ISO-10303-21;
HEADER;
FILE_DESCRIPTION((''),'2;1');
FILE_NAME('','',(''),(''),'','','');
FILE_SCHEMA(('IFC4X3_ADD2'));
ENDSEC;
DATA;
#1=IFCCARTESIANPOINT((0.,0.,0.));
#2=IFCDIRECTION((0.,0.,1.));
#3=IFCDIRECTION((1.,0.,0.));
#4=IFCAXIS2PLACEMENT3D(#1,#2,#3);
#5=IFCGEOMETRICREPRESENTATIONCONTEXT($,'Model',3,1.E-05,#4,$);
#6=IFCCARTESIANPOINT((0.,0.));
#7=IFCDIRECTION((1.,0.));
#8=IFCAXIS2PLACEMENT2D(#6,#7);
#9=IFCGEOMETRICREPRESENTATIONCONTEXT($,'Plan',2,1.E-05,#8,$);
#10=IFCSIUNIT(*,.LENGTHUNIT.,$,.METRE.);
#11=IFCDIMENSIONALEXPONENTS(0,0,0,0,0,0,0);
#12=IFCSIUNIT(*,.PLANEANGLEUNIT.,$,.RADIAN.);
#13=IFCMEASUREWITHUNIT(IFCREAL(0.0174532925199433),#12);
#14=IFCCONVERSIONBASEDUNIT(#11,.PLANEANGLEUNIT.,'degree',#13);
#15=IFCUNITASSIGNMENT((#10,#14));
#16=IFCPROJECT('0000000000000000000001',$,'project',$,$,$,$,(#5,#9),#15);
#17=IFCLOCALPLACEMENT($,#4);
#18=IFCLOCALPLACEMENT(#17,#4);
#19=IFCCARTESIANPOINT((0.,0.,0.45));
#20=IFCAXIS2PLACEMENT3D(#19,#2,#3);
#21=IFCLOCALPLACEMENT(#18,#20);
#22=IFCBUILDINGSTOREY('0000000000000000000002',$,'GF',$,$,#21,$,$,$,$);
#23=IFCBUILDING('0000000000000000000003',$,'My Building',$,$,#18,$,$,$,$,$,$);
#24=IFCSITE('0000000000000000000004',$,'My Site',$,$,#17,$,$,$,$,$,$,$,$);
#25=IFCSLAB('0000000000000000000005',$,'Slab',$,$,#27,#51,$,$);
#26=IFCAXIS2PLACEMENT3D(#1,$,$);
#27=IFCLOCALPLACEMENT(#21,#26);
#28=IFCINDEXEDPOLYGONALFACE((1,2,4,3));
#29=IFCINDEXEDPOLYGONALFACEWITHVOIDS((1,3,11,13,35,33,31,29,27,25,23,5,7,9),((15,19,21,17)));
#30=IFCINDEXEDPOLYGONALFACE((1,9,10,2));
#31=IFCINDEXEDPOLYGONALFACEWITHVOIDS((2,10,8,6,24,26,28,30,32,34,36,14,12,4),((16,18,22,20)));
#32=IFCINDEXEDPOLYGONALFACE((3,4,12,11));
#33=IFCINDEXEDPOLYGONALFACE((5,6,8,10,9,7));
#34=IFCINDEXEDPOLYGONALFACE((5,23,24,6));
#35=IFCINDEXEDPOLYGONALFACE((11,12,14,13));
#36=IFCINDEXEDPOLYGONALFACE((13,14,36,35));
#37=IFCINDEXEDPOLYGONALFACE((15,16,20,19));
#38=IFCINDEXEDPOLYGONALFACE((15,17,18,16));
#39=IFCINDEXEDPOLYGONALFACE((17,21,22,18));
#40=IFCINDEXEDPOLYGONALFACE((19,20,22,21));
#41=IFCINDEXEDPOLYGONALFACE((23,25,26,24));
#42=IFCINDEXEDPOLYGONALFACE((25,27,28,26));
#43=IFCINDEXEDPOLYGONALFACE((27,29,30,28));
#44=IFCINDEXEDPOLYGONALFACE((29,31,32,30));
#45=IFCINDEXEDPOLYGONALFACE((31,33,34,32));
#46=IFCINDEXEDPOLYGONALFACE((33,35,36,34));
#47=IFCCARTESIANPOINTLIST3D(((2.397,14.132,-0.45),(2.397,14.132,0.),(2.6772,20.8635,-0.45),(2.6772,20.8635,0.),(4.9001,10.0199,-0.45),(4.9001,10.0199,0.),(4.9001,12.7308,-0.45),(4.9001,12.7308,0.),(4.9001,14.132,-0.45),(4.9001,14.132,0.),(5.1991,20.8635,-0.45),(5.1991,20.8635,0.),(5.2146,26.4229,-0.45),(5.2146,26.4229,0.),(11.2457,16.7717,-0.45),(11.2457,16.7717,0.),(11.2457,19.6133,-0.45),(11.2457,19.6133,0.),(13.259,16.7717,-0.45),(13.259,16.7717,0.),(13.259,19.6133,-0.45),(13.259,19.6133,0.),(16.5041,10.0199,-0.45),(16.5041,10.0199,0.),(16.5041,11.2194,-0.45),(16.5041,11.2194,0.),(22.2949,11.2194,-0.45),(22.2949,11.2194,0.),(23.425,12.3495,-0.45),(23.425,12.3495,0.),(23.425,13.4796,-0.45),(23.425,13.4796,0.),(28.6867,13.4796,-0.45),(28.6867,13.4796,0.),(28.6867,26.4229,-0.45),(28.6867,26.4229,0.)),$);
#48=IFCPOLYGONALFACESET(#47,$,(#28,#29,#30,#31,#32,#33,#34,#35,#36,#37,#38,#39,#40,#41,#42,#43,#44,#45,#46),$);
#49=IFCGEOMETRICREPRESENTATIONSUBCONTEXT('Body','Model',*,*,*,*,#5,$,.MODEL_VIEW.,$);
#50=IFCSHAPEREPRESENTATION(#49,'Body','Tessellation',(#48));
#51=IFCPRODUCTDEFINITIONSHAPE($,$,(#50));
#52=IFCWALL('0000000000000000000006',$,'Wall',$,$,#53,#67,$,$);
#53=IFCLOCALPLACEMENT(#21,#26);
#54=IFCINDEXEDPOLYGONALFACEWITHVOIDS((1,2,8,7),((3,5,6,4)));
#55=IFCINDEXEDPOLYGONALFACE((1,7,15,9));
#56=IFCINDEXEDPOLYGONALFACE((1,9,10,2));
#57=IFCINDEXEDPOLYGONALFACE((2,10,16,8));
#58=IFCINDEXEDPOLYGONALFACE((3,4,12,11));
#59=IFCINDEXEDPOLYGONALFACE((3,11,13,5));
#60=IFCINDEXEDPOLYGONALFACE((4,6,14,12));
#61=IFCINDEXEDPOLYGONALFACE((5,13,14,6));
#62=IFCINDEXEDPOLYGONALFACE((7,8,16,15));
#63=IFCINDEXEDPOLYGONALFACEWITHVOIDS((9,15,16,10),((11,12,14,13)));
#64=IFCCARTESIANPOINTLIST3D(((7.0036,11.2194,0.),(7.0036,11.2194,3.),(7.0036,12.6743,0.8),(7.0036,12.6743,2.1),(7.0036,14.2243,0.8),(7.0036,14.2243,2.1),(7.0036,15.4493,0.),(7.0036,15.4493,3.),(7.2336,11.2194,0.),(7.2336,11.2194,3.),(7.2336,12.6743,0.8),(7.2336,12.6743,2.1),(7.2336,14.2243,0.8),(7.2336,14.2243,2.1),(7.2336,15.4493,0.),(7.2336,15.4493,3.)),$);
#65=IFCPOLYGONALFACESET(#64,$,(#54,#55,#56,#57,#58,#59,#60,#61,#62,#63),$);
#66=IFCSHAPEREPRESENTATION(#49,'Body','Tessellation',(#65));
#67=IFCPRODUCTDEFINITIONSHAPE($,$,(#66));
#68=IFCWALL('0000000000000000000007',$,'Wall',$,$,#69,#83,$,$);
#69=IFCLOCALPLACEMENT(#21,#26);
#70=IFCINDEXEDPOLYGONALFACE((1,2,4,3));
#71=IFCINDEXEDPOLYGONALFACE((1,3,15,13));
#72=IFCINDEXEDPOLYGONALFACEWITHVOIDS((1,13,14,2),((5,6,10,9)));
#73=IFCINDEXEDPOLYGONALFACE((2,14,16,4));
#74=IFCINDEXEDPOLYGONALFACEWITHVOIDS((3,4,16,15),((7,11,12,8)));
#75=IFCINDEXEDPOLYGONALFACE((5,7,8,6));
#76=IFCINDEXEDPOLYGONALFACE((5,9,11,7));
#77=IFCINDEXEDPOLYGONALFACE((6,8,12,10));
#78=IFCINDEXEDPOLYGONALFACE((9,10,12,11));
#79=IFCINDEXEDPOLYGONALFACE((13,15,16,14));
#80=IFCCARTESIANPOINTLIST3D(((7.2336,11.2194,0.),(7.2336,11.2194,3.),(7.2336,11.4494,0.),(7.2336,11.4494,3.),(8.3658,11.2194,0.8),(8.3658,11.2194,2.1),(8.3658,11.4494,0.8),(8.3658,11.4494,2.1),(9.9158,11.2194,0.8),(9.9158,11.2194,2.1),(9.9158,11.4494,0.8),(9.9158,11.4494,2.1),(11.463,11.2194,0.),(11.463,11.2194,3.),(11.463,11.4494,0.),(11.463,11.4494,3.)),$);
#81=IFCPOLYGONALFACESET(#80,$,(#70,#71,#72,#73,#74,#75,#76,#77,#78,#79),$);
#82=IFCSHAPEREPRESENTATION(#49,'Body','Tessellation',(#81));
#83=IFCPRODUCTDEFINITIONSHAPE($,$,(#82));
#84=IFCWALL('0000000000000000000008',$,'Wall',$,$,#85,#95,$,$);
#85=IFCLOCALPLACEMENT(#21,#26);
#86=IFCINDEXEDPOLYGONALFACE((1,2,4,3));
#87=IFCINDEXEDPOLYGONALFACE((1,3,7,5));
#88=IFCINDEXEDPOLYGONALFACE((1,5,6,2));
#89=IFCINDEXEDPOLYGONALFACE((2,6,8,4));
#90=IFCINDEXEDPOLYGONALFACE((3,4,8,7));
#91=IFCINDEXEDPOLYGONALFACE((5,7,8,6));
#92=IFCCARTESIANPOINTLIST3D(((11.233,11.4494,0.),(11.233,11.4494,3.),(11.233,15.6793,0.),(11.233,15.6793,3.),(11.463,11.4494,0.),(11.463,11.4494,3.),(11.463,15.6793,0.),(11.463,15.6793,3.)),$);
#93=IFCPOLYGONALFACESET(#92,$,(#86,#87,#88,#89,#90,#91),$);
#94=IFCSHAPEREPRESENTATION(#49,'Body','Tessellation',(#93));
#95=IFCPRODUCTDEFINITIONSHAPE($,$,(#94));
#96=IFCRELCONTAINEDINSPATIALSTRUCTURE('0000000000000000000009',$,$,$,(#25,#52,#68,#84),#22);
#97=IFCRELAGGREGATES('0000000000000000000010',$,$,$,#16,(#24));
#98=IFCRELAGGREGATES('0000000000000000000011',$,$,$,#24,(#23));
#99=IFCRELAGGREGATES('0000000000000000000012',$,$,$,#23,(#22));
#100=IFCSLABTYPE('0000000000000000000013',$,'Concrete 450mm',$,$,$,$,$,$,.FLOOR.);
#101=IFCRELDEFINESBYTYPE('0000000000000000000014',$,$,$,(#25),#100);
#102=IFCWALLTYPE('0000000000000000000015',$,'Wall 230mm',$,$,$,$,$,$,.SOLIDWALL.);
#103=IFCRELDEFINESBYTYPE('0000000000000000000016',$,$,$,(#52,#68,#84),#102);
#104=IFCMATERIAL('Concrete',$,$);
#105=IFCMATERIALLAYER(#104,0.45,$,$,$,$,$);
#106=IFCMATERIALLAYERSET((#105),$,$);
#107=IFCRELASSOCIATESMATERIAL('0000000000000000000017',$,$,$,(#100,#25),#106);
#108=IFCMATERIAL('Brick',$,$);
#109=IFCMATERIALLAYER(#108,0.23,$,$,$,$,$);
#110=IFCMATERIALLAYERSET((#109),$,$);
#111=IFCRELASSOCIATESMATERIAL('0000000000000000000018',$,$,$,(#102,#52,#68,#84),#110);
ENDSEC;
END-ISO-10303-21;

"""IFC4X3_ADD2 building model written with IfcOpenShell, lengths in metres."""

from ifc_helpers import new_model, entity, si_unit, converted_unit, frame, origin_with_axes, origin_2d_with_axis, place, context, subcontext, project, spatial, line, indexed_curve, outline, extrude, source, transform, mapped, material, layer, layer_set, layer_usage, type_object, element, save


model = new_model("IFC4X3_ADD2")

# Units and contexts
model_context = context("Model", 3, precision=1e-05, world=origin_with_axes())
plan_context = context("Plan", 2, precision=1e-05, world=origin_2d_with_axis())
body_context_1 = subcontext(model_context, "Body", "Model", "MODEL_VIEW")
ifc_project = project(units=[si_unit("LENGTHUNIT", "METRE"), converted_unit("PLANEANGLEUNIT", "degree", entity("IfcReal", 0.0174532925199433), si_unit("PLANEANGLEUNIT", "RADIAN"), dimensions=[0, 0, 0, 0, 0, 0, 0])], contexts=[model_context, plan_context])

# Site, building, storey
site_placement = place(None, origin_with_axes())
site = spatial("IfcSite", under=ifc_project, at=site_placement, Name="My Site")
building_placement = place(site_placement, origin_with_axes())
building = spatial("IfcBuilding", under=site, at=building_placement, Name="My Building")
storey_placement = place(building_placement, frame((0.0, 0.0, 0.45), z_axis=(0.0, 0.0, 1.0), x_axis=(1.0, 0.0, 0.0)))
storey = spatial("IfcBuildingStorey", under=building, at=storey_placement, Name="GF")

# Slab
ifc_material_1 = material(Name="Concrete")
ifc_layer_1 = layer(ifc_material_1, 0.45)
ifc_layer_set_1 = layer_set([ifc_layer_1])
ifc_layer_usage_1 = layer_usage(ifc_layer_set_1, "AXIS3", "POSITIVE", 0.0)
slab_type = type_object("IfcSlabType", Name="Concrete 450mm", PredefinedType="FLOOR", material=ifc_layer_set_1)
slab_placement = place(storey_placement, frame((4.9001, 10.0199, -0.45), z_axis=(0.0, 0.0, 1.0), x_axis=(1.0, 0.0, 0.0)))
element("IfcSlab", 1, at=slab_placement, inside=storey, type_object=slab_type, material=ifc_layer_usage_1, Name="Slab", context=body_context_1, shape_type="SweptSolid", body=[
    extrude(outline(indexed_curve([(17.3948, 1.1995), (18.5249, 2.3296), (18.5249, 3.4597), (23.7866, 3.4597), (23.7866, 16.403), (0.3146, 16.403), (0.299, 10.8436), (-2.2229, 10.8436), (-2.5031, 4.1121), (0.0, 4.1121), (0.0, 2.7109), (0.0, 0.0), (11.604, 0.0), (11.604, 1.1995), (6.3456, 9.5934), (6.3456, 6.7518), (8.3589, 6.7518), (8.3589, 9.5934)], segments=[line(6, 5), line(5, 4), line(4, 3), line(3, 2), line(2, 1), line(1, 14), line(14, 13), line(13, 12), line(12, 11), line(11, 10), line(10, 9), line(9, 8), line(8, 7), line(7, 6)], self_intersect=False), holes=[indexed_curve([(17.3948, 1.1995), (18.5249, 2.3296), (18.5249, 3.4597), (23.7866, 3.4597), (23.7866, 16.403), (0.3146, 16.403), (0.299, 10.8436), (-2.2229, 10.8436), (-2.5031, 4.1121), (0.0, 4.1121), (0.0, 2.7109), (0.0, 0.0), (11.604, 0.0), (11.604, 1.1995), (6.3456, 9.5934), (6.3456, 6.7518), (8.3589, 6.7518), (8.3589, 9.5934)], segments=[line(18, 17), line(17, 16), line(16, 15), line(15, 18)], self_intersect=False)]), None, (0.0, 0.0, 1.0), 0.45),
])

# Walls, openings
ifc_material_2 = material(Name="Brick")
ifc_layer_2 = layer(ifc_material_2, 0.23)
ifc_layer_set_2 = layer_set([ifc_layer_2])
ifc_layer_usage_2 = layer_usage(ifc_layer_set_2, "AXIS2", "POSITIVE", 0.0)
wall_type = type_object("IfcWallType", Name="Wall 230mm", PredefinedType="SOLIDWALL", material=ifc_layer_set_2)
wall_1_placement = place(storey_placement, frame((7.2336, 11.2194, 0.0), z_axis=(0.0, 0.0, 1.0), x_axis=(0.0, 1.0, 0.0)))
wall_1 = element("IfcWall", 2, at=wall_1_placement, inside=storey, type_object=wall_type, material=ifc_layer_usage_2, Name="Wall", context=body_context_1, shape_type="SweptSolid", body=[
    extrude(outline(indexed_curve([(0.0, 0.0), (0.0, 0.23), (4.23, 0.23), (4.23, 0.0), (0.0, 0.0)], self_intersect=False)), origin_with_axes(), (0.0, 0.0, 1.0), 3.0),
])
shared_shape_1 = source(origin_with_axes(), body_context_1, "Body", "SweptSolid", [
    extrude(outline(indexed_curve([(0.0, 0.0), (1.55, 0.0), (1.55, 1.3), (0.0, 1.3)], segments=[line(1, 2, 3, 4, 1)])), frame((-0.775, -0.6, 0.0), z_axis=(0.0, -1.0, 0.0), x_axis=(1.0, 0.0, 0.0)), (0.0, 0.0, -1.0), 1.2),
])
opening_1_placement = place(wall_1_placement, frame((2.23, 0.0, 0.8), z_axis=(0.0, 0.0, 1.0), x_axis=(1.0, 0.0, 0.0)))
element("IfcOpeningElement", 3, at=opening_1_placement, cuts=wall_1, PredefinedType="OPENING", context=body_context_1, shape_type="MappedRepresentation", body=[
    mapped(shared_shape_1, transform((0.0, 0.0, 0.0), x_axis=(1.0, 0.0, 0.0), y_axis=(0.0, 1.0, 0.0), z_axis=(0.0, 0.0, 1.0), scale=1.0)),
])
ifc_layer_usage_3 = layer_usage(ifc_layer_set_2, "AXIS2", "POSITIVE", 0.0)
wall_2_placement = place(storey_placement, frame((7.2336, 11.2194, 0.0), z_axis=(0.0, 0.0, 1.0), x_axis=(1.0, 0.0, 0.0)))
wall_2 = element("IfcWall", 4, at=wall_2_placement, inside=storey, type_object=wall_type, material=ifc_layer_usage_3, Name="Wall", context=body_context_1, shape_type="SweptSolid", body=[
    extrude(outline(indexed_curve([(0.0, 0.0), (0.0, 0.23), (4.2294, 0.23), (4.2294, 0.0), (0.0, 0.0)], self_intersect=False)), origin_with_axes(), (0.0, 0.0, 1.0), 3.0),
])
opening_2_placement = place(wall_2_placement, frame((1.9072, 0.015, 0.8), z_axis=(0.0, 0.0, 1.0), x_axis=(1.0, 0.0, 0.0)))
element("IfcOpeningElement", 5, at=opening_2_placement, cuts=wall_2, PredefinedType="OPENING", context=body_context_1, shape_type="MappedRepresentation", body=[
    mapped(shared_shape_1, transform((0.0, 0.0, 0.0), x_axis=(1.0, 0.0, 0.0), y_axis=(0.0, 1.0, 0.0), z_axis=(0.0, 0.0, 1.0), scale=1.0)),
])

# Wall
ifc_layer_usage_4 = layer_usage(ifc_layer_set_2, "AXIS2", "POSITIVE", 0.0)
wall_3_placement = place(storey_placement, frame((11.463, 11.4494, 0.0), z_axis=(0.0, 0.0, 1.0), x_axis=(0.0, 1.0, 0.0)))
element("IfcWall", 6, at=wall_3_placement, inside=storey, type_object=wall_type, material=ifc_layer_usage_4, Name="Wall", context=body_context_1, shape_type="SweptSolid", body=[
    extrude(outline(indexed_curve([(0.0, 0.0), (0.0, 0.23), (4.23, 0.23), (4.23, 0.0), (0.0, 0.0)], self_intersect=False)), origin_with_axes(), (0.0, 0.0, 1.0), 3.0),
])

save(model, "model.ifc")
